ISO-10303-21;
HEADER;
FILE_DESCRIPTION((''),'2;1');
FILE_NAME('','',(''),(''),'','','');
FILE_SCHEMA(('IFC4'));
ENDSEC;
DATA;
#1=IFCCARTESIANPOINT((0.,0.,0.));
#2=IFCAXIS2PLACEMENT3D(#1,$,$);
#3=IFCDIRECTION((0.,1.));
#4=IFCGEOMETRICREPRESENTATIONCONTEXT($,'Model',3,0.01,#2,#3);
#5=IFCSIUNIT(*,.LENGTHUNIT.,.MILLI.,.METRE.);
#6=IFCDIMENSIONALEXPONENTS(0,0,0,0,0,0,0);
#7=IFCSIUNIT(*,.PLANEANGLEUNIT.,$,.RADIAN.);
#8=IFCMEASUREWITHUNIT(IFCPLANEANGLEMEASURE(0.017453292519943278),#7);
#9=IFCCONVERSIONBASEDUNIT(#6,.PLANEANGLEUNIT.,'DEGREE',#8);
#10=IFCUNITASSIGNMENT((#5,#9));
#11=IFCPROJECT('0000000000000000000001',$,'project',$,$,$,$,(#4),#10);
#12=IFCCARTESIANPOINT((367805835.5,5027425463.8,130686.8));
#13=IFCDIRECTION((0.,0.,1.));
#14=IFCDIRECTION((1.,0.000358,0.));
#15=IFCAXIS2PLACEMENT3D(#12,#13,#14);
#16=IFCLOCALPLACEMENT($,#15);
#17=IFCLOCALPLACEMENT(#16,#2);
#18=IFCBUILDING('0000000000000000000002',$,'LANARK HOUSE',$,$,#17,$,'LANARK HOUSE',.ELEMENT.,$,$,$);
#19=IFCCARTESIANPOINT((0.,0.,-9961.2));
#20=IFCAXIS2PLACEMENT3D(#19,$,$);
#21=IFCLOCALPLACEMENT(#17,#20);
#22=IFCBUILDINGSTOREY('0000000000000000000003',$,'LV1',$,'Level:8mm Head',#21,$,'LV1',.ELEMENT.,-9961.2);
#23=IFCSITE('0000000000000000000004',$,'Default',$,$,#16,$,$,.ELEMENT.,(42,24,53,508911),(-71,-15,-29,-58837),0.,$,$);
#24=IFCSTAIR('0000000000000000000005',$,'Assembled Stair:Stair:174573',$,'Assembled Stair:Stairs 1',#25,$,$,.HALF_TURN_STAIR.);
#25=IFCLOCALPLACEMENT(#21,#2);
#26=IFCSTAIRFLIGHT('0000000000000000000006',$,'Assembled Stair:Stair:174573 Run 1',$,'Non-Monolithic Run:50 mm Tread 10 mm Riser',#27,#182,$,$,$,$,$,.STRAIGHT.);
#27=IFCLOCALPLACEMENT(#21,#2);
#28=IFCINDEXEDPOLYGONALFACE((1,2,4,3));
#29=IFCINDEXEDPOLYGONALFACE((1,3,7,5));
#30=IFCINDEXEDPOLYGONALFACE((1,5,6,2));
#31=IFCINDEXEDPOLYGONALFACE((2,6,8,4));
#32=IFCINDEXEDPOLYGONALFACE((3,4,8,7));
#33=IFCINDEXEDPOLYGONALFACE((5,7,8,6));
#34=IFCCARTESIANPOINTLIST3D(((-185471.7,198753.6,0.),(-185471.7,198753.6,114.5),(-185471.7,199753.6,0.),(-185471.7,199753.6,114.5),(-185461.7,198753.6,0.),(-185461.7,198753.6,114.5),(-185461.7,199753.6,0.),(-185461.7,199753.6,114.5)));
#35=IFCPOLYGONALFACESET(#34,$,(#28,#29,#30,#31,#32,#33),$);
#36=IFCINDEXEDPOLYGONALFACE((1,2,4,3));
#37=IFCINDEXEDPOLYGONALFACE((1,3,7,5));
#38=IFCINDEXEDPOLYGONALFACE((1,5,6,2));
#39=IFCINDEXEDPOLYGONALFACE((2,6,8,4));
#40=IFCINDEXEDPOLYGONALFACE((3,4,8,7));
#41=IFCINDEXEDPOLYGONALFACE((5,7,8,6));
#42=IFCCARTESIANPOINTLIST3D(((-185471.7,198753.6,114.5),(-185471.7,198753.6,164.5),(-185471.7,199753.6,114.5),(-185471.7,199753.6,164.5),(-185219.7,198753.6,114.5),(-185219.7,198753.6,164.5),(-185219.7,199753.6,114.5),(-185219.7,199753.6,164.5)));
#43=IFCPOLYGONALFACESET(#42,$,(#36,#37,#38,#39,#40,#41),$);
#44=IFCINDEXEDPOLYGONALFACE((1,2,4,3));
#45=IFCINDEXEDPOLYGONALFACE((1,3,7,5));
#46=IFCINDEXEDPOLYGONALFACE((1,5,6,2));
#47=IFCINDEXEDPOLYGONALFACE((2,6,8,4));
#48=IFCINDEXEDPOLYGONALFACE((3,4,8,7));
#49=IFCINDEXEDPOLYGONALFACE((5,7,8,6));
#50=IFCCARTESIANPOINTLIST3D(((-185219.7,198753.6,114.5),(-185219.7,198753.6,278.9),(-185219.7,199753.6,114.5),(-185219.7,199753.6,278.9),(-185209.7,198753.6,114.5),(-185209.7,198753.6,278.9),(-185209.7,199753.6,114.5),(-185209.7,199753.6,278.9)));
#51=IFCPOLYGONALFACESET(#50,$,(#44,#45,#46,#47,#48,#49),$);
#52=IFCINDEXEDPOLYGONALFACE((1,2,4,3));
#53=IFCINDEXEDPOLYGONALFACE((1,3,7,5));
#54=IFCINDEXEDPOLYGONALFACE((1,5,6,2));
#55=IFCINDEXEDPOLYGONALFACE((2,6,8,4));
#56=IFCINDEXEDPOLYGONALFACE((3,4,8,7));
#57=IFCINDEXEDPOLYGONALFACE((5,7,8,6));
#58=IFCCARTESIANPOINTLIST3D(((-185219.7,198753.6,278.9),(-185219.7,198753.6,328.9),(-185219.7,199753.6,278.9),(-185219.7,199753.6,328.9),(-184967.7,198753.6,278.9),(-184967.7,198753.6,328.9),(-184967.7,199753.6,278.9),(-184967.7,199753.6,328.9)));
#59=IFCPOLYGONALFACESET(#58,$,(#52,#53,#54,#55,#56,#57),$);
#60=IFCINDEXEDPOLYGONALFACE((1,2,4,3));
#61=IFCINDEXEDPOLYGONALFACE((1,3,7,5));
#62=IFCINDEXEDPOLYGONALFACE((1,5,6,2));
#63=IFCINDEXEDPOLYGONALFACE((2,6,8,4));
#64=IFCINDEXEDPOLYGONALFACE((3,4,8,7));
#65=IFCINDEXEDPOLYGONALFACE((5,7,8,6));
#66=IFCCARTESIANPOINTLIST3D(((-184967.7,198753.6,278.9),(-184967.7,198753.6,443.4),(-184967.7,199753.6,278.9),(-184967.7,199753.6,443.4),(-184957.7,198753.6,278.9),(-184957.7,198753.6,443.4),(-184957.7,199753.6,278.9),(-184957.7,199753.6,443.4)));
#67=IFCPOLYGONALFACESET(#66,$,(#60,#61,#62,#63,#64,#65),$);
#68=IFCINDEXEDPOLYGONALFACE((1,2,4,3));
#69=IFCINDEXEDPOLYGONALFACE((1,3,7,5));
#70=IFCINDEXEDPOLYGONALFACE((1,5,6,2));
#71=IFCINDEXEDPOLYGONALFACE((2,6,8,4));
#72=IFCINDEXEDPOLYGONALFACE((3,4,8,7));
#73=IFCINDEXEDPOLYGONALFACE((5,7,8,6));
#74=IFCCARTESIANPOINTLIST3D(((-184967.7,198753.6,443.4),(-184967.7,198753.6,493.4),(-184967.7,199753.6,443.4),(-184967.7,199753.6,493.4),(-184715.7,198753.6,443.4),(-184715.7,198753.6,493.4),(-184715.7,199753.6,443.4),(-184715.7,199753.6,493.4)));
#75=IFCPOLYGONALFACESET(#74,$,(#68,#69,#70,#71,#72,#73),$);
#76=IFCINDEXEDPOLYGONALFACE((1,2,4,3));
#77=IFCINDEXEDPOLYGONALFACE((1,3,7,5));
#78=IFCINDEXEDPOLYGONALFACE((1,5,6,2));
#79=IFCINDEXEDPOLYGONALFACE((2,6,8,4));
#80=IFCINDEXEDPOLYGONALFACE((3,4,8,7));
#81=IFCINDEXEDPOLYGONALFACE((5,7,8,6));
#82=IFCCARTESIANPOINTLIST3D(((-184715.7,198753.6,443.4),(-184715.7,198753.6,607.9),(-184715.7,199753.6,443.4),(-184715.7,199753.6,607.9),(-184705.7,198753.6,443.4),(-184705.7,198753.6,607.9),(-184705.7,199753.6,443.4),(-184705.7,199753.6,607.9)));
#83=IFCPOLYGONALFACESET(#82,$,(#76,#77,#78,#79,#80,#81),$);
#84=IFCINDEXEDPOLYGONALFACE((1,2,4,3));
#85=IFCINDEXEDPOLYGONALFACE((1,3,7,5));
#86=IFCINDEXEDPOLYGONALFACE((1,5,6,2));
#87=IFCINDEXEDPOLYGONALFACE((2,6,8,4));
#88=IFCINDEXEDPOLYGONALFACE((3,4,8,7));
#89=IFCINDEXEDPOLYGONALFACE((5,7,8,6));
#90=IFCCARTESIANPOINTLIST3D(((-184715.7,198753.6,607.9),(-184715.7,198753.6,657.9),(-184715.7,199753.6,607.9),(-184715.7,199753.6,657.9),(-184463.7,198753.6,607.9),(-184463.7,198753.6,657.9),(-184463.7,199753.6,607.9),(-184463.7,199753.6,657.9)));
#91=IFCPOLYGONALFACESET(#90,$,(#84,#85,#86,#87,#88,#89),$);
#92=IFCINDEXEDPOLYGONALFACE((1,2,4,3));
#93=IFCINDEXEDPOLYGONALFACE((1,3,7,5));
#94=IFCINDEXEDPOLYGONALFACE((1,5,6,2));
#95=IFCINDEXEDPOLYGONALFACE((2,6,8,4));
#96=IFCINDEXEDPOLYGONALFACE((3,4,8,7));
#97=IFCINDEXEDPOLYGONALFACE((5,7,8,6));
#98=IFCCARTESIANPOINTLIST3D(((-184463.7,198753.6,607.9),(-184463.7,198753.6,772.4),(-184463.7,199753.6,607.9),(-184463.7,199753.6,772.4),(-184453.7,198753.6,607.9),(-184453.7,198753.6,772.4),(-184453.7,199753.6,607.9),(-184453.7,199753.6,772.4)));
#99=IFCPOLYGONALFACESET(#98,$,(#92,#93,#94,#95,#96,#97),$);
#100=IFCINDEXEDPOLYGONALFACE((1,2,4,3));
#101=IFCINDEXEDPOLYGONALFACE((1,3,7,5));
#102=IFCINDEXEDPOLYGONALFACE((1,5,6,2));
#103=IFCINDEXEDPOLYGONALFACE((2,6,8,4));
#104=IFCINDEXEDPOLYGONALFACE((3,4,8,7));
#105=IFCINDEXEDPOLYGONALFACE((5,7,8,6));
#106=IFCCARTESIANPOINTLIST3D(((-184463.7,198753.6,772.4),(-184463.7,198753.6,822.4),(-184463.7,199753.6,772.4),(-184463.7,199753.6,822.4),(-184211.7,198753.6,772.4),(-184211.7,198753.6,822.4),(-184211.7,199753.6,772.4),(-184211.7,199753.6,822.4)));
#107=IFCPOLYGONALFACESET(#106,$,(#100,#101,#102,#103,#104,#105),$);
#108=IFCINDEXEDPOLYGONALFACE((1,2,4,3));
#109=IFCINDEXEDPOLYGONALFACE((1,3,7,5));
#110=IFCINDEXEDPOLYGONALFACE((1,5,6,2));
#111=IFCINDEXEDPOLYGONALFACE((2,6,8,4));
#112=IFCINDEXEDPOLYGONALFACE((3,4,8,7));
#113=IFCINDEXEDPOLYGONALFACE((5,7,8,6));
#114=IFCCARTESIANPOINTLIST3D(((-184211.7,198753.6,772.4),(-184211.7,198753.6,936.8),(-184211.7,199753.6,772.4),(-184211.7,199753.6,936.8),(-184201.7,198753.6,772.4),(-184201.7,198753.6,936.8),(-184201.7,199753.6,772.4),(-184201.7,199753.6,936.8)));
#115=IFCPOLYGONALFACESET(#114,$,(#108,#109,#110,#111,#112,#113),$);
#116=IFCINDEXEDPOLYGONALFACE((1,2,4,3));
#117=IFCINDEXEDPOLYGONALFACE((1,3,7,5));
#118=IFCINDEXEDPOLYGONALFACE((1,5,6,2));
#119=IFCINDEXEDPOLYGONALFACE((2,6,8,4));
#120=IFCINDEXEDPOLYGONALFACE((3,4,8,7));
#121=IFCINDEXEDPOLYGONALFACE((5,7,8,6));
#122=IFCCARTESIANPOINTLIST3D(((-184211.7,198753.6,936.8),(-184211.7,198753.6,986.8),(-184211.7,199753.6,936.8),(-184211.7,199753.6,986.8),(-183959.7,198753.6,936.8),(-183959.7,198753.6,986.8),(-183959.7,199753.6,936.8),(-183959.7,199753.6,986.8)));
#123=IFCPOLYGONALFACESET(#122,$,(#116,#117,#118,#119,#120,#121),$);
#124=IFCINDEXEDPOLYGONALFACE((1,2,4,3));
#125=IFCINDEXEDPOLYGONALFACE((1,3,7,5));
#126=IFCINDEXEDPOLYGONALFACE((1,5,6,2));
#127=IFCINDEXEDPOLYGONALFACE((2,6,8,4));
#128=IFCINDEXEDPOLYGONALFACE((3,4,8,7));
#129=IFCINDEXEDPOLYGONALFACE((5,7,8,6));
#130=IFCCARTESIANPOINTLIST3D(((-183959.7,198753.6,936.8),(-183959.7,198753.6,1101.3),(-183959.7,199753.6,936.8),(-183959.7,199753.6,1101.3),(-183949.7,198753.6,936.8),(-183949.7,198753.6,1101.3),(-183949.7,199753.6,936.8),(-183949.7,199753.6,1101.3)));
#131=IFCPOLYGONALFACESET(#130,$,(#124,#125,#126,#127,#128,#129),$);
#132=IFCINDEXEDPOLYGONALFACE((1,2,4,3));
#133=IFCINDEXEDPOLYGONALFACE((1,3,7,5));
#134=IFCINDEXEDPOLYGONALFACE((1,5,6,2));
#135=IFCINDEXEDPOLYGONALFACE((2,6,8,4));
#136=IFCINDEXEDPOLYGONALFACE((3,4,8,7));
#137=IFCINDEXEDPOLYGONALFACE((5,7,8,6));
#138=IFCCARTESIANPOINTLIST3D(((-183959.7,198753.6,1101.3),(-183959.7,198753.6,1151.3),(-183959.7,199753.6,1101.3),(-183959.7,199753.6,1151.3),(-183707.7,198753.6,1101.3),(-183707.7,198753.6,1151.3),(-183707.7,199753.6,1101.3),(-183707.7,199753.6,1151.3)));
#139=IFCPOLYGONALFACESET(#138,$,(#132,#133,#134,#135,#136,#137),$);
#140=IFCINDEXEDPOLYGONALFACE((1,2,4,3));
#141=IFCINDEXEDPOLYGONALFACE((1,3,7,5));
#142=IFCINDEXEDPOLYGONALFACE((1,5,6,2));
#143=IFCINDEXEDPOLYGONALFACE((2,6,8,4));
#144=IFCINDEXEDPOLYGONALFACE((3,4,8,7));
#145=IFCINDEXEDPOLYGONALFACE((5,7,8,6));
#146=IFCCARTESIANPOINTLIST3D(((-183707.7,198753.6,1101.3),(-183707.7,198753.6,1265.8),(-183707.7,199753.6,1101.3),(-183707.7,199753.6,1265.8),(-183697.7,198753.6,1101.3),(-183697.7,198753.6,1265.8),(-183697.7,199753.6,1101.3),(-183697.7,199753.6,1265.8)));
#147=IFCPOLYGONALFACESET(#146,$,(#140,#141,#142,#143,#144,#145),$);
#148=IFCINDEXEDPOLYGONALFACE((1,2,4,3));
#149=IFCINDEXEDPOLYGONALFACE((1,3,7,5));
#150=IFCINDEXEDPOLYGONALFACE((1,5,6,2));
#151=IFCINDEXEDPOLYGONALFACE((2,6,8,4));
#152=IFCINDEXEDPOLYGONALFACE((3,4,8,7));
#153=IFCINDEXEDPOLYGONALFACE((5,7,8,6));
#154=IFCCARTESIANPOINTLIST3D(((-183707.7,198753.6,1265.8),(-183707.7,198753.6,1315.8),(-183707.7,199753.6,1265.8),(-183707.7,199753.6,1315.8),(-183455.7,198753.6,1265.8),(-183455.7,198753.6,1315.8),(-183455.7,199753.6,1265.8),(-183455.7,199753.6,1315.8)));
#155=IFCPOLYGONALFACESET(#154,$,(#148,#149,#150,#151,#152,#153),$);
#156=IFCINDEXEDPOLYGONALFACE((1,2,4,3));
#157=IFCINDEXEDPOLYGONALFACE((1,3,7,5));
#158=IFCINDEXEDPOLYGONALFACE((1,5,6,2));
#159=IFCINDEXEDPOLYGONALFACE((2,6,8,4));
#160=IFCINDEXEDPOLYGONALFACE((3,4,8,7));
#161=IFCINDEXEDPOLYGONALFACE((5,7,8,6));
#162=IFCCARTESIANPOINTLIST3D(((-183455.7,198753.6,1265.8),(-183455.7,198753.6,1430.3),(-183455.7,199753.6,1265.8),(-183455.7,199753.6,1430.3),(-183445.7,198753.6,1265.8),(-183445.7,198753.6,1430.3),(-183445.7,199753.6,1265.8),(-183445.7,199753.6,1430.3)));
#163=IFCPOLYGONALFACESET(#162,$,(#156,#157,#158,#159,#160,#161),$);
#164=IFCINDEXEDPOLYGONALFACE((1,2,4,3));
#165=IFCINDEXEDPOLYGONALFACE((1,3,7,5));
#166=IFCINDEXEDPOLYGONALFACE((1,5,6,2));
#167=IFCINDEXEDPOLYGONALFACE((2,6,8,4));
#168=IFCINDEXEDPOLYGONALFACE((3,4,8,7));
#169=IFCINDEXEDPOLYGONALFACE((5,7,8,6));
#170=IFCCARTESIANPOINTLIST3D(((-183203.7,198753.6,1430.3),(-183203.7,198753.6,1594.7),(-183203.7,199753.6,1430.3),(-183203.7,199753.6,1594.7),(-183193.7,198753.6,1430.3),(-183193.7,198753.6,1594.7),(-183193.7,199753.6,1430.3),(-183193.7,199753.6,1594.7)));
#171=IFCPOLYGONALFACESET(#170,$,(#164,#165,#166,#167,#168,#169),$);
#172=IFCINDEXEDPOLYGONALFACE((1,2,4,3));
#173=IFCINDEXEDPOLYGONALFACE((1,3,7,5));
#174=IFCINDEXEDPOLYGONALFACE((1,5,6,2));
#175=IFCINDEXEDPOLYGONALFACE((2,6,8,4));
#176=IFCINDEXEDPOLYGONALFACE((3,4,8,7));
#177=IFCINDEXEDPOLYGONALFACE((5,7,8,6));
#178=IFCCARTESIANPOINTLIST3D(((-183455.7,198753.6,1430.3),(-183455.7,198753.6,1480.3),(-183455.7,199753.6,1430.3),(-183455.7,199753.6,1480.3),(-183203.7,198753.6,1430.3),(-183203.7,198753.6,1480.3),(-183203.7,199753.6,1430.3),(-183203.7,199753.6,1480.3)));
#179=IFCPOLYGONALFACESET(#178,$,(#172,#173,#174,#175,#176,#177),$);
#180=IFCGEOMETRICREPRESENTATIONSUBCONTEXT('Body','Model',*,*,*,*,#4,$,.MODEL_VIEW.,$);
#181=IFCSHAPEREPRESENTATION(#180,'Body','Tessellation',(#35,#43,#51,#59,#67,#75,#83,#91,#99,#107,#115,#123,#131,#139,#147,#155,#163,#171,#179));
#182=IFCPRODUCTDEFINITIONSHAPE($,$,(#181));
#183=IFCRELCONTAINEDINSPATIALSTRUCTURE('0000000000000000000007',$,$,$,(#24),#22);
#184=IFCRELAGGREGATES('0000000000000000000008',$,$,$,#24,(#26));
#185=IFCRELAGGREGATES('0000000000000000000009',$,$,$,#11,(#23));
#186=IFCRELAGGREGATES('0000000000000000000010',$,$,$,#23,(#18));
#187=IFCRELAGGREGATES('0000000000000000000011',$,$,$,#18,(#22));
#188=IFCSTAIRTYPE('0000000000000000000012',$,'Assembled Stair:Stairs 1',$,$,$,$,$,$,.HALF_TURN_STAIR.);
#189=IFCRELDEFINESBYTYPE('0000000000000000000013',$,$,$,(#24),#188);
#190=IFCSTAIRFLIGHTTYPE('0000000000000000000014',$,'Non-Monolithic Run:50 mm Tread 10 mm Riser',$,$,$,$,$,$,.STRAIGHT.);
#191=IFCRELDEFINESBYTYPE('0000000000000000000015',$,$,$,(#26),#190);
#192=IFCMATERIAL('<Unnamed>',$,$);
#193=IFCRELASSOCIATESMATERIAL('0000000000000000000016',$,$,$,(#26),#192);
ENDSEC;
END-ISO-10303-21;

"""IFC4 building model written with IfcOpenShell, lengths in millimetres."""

from ifc_helpers import new_model, entity, si_unit, converted_unit, direction, frame, origin, place, context, subcontext, project, spatial, indexed_curve, outline, extrude, material, type_object, element, aggregate, save


model = new_model("IFC4")

# Units and contexts
model_context = context("Model", 3, precision=0.01, world=origin(), true_north=direction((0.0, 1.0)))
body_context = subcontext(model_context, "Body", "Model", "MODEL_VIEW")
ifc_project = project(units=[si_unit("LENGTHUNIT", "METRE", prefix="MILLI"), converted_unit("PLANEANGLEUNIT", "DEGREE", entity("IfcPlaneAngleMeasure", 0.017453292519943278), si_unit("PLANEANGLEUNIT", "RADIAN"), dimensions=[0, 0, 0, 0, 0, 0, 0])], contexts=[model_context])

# Site, building, storey
site_placement = place(None, frame((367805835.5, 5027425463.8, 130686.8), z_axis=(0.0, 0.0, 1.0), x_axis=(1.0, 0.000358, 0.0)))
site = spatial("IfcSite", under=ifc_project, at=site_placement, Name="Default", CompositionType="ELEMENT", RefLatitude=(42, 24, 53, 508911), RefLongitude=(-71, -15, -29, -58837), RefElevation=0.0)
building_placement = place(site_placement, origin())
building = spatial("IfcBuilding", under=site, at=building_placement, Name="LANARK HOUSE", LongName="LANARK HOUSE", CompositionType="ELEMENT")
storey_placement = place(building_placement, frame((0.0, 0.0, -9961.2)))
storey = spatial("IfcBuildingStorey", under=building, at=storey_placement, Name="LV1", ObjectType="Level:8mm Head", LongName="LV1", CompositionType="ELEMENT", Elevation=-9961.2)

# Stair
stair_type = type_object("IfcStairType", Name="Assembled Stair:Stairs 1", PredefinedType="HALF_TURN_STAIR")
stair_placement = place(storey_placement, origin())
stair = element("IfcStair", 1, at=stair_placement, inside=storey, type_object=stair_type, Name="Assembled Stair:Stair:174573", ObjectType="Assembled Stair:Stairs 1", PredefinedType="HALF_TURN_STAIR")
ifc_material_1 = material(Name="<Unnamed>")

# Stair flight
stair_flight_type = type_object("IfcStairFlightType", Name="Non-Monolithic Run:50 mm Tread 10 mm Riser", PredefinedType="STRAIGHT")
stair_flight_1_placement = place(stair_placement, frame((-185471.7, 198753.6, 0.0)))
stair_flight_1 = element("IfcStairFlight", 2, at=stair_flight_1_placement, type_object=stair_flight_type, material=ifc_material_1, Name="Assembled Stair:Stair:174573 Run 1", ObjectType="Non-Monolithic Run:50 mm Tread 10 mm Riser", PredefinedType="STRAIGHT", context=body_context, shape_type="SweptSolid", body=[
    extrude(outline(indexed_curve([(-500.0, -5.0), (500.0, -5.0), (500.0, 5.0), (-500.0, 5.0), (-500.0, -5.0)], self_intersect=False)), frame((5.0, 500.0, 0.0), z_axis=(0.0, 0.0, 1.0), x_axis=(0.0, 1.0, 0.0)), (0.0, 0.0, 1.0), 114.5),
    extrude(outline(indexed_curve([(-126.0, -500.0), (126.0, -500.0), (126.0, 500.0), (-126.0, 500.0), (-126.0, -500.0)], self_intersect=False)), frame((126.0, 500.0, 114.5), z_axis=(0.0, 0.0, 1.0), x_axis=(-1.0, 0.0, 0.0)), (0.0, 0.0, 1.0), 50.0),
    extrude(outline(indexed_curve([(-500.0, -5.0), (500.0, -5.0), (500.0, 5.0), (-500.0, 5.0), (-500.0, -5.0)], self_intersect=False)), frame((257.0, 500.0, 114.5), z_axis=(0.0, 0.0, 1.0), x_axis=(0.0, 1.0, 0.0)), (0.0, 0.0, 1.0), 164.5),
    extrude(outline(indexed_curve([(-126.0, -500.0), (126.0, -500.0), (126.0, 500.0), (-126.0, 500.0), (-126.0, -500.0)], self_intersect=False)), frame((378.0, 500.0, 278.9), z_axis=(0.0, 0.0, 1.0), x_axis=(-1.0, 0.0, 0.0)), (0.0, 0.0, 1.0), 50.0),
    extrude(outline(indexed_curve([(-500.0, -5.0), (500.0, -5.0), (500.0, 5.0), (-500.0, 5.0), (-500.0, -5.0)], self_intersect=False)), frame((509.0, 500.0, 278.9), z_axis=(0.0, 0.0, 1.0), x_axis=(0.0, 1.0, 0.0)), (0.0, 0.0, 1.0), 164.5),
    extrude(outline(indexed_curve([(-126.0, -500.0), (126.0, -500.0), (126.0, 500.0), (-126.0, 500.0), (-126.0, -500.0)], self_intersect=False)), frame((630.0, 500.0, 443.4), z_axis=(0.0, 0.0, 1.0), x_axis=(-1.0, 0.0, 0.0)), (0.0, 0.0, 1.0), 50.0),
    extrude(outline(indexed_curve([(-500.0, -5.0), (500.0, -5.0), (500.0, 5.0), (-500.0, 5.0), (-500.0, -5.0)], self_intersect=False)), frame((761.0, 500.0, 443.4), z_axis=(0.0, 0.0, 1.0), x_axis=(0.0, 1.0, 0.0)), (0.0, 0.0, 1.0), 164.5),
    extrude(outline(indexed_curve([(-126.0, -500.0), (126.0, -500.0), (126.0, 500.0), (-126.0, 500.0), (-126.0, -500.0)], self_intersect=False)), frame((882.0, 500.0, 607.9), z_axis=(0.0, 0.0, 1.0), x_axis=(-1.0, 0.0, 0.0)), (0.0, 0.0, 1.0), 50.0),
    extrude(outline(indexed_curve([(-500.0, -5.0), (500.0, -5.0), (500.0, 5.0), (-500.0, 5.0), (-500.0, -5.0)], self_intersect=False)), frame((1013.0, 500.0, 607.9), z_axis=(0.0, 0.0, 1.0), x_axis=(0.0, 1.0, 0.0)), (0.0, 0.0, 1.0), 164.5),
    extrude(outline(indexed_curve([(-126.0, -500.0), (126.0, -500.0), (126.0, 500.0), (-126.0, 500.0), (-126.0, -500.0)], self_intersect=False)), frame((1134.0, 500.0, 772.4), z_axis=(0.0, 0.0, 1.0), x_axis=(-1.0, 0.0, 0.0)), (0.0, 0.0, 1.0), 50.0),
    extrude(outline(indexed_curve([(-500.0, -5.0), (500.0, -5.0), (500.0, 5.0), (-500.0, 5.0), (-500.0, -5.0)], self_intersect=False)), frame((1265.0, 500.0, 772.4), z_axis=(0.0, 0.0, 1.0), x_axis=(0.0, 1.0, 0.0)), (0.0, 0.0, 1.0), 164.5),
    extrude(outline(indexed_curve([(-126.0, -500.0), (126.0, -500.0), (126.0, 500.0), (-126.0, 500.0), (-126.0, -500.0)], self_intersect=False)), frame((1386.0, 500.0, 936.8), z_axis=(0.0, 0.0, 1.0), x_axis=(-1.0, 0.0, 0.0)), (0.0, 0.0, 1.0), 50.0),
    extrude(outline(indexed_curve([(-500.0, -5.0), (500.0, -5.0), (500.0, 5.0), (-500.0, 5.0), (-500.0, -5.0)], self_intersect=False)), frame((1517.0, 500.0, 936.8), z_axis=(0.0, 0.0, 1.0), x_axis=(0.0, 1.0, 0.0)), (0.0, 0.0, 1.0), 164.5),
    extrude(outline(indexed_curve([(-126.0, -500.0), (126.0, -500.0), (126.0, 500.0), (-126.0, 500.0), (-126.0, -500.0)], self_intersect=False)), frame((1638.0, 500.0, 1101.3), z_axis=(0.0, 0.0, 1.0), x_axis=(-1.0, 0.0, 0.0)), (0.0, 0.0, 1.0), 50.0),
    extrude(outline(indexed_curve([(-500.0, -5.0), (500.0, -5.0), (500.0, 5.0), (-500.0, 5.0), (-500.0, -5.0)], self_intersect=False)), frame((1769.0, 500.0, 1101.3), z_axis=(0.0, 0.0, 1.0), x_axis=(0.0, 1.0, 0.0)), (0.0, 0.0, 1.0), 164.5),
    extrude(outline(indexed_curve([(-126.0, -500.0), (126.0, -500.0), (126.0, 500.0), (-126.0, 500.0), (-126.0, -500.0)], self_intersect=False)), frame((1890.0, 500.0, 1265.8), z_axis=(0.0, 0.0, 1.0), x_axis=(-1.0, 0.0, 0.0)), (0.0, 0.0, 1.0), 50.0),
    extrude(outline(indexed_curve([(-500.0, -5.0), (500.0, -5.0), (500.0, 5.0), (-500.0, 5.0), (-500.0, -5.0)], self_intersect=False)), frame((2021.0, 500.0, 1265.8), z_axis=(0.0, 0.0, 1.0), x_axis=(0.0, 1.0, 0.0)), (0.0, 0.0, 1.0), 164.5),
    extrude(outline(indexed_curve([(-500.0, -5.0), (500.0, -5.0), (500.0, 5.0), (-500.0, 5.0), (-500.0, -5.0)], self_intersect=False)), frame((2273.0, 500.0, 1430.3), z_axis=(0.0, 0.0, 1.0), x_axis=(0.0, 1.0, 0.0)), (0.0, 0.0, 1.0), 164.5),
    extrude(outline(indexed_curve([(-126.0, -500.0), (126.0, -500.0), (126.0, 500.0), (-126.0, 500.0), (-126.0, -500.0)], self_intersect=False)), frame((2142.0, 500.0, 1430.3), z_axis=(0.0, 0.0, 1.0), x_axis=(-1.0, 0.0, 0.0)), (0.0, 0.0, 1.0), 50.0),
])

aggregate(stair, [stair_flight_1])

save(model, "model.ifc")
